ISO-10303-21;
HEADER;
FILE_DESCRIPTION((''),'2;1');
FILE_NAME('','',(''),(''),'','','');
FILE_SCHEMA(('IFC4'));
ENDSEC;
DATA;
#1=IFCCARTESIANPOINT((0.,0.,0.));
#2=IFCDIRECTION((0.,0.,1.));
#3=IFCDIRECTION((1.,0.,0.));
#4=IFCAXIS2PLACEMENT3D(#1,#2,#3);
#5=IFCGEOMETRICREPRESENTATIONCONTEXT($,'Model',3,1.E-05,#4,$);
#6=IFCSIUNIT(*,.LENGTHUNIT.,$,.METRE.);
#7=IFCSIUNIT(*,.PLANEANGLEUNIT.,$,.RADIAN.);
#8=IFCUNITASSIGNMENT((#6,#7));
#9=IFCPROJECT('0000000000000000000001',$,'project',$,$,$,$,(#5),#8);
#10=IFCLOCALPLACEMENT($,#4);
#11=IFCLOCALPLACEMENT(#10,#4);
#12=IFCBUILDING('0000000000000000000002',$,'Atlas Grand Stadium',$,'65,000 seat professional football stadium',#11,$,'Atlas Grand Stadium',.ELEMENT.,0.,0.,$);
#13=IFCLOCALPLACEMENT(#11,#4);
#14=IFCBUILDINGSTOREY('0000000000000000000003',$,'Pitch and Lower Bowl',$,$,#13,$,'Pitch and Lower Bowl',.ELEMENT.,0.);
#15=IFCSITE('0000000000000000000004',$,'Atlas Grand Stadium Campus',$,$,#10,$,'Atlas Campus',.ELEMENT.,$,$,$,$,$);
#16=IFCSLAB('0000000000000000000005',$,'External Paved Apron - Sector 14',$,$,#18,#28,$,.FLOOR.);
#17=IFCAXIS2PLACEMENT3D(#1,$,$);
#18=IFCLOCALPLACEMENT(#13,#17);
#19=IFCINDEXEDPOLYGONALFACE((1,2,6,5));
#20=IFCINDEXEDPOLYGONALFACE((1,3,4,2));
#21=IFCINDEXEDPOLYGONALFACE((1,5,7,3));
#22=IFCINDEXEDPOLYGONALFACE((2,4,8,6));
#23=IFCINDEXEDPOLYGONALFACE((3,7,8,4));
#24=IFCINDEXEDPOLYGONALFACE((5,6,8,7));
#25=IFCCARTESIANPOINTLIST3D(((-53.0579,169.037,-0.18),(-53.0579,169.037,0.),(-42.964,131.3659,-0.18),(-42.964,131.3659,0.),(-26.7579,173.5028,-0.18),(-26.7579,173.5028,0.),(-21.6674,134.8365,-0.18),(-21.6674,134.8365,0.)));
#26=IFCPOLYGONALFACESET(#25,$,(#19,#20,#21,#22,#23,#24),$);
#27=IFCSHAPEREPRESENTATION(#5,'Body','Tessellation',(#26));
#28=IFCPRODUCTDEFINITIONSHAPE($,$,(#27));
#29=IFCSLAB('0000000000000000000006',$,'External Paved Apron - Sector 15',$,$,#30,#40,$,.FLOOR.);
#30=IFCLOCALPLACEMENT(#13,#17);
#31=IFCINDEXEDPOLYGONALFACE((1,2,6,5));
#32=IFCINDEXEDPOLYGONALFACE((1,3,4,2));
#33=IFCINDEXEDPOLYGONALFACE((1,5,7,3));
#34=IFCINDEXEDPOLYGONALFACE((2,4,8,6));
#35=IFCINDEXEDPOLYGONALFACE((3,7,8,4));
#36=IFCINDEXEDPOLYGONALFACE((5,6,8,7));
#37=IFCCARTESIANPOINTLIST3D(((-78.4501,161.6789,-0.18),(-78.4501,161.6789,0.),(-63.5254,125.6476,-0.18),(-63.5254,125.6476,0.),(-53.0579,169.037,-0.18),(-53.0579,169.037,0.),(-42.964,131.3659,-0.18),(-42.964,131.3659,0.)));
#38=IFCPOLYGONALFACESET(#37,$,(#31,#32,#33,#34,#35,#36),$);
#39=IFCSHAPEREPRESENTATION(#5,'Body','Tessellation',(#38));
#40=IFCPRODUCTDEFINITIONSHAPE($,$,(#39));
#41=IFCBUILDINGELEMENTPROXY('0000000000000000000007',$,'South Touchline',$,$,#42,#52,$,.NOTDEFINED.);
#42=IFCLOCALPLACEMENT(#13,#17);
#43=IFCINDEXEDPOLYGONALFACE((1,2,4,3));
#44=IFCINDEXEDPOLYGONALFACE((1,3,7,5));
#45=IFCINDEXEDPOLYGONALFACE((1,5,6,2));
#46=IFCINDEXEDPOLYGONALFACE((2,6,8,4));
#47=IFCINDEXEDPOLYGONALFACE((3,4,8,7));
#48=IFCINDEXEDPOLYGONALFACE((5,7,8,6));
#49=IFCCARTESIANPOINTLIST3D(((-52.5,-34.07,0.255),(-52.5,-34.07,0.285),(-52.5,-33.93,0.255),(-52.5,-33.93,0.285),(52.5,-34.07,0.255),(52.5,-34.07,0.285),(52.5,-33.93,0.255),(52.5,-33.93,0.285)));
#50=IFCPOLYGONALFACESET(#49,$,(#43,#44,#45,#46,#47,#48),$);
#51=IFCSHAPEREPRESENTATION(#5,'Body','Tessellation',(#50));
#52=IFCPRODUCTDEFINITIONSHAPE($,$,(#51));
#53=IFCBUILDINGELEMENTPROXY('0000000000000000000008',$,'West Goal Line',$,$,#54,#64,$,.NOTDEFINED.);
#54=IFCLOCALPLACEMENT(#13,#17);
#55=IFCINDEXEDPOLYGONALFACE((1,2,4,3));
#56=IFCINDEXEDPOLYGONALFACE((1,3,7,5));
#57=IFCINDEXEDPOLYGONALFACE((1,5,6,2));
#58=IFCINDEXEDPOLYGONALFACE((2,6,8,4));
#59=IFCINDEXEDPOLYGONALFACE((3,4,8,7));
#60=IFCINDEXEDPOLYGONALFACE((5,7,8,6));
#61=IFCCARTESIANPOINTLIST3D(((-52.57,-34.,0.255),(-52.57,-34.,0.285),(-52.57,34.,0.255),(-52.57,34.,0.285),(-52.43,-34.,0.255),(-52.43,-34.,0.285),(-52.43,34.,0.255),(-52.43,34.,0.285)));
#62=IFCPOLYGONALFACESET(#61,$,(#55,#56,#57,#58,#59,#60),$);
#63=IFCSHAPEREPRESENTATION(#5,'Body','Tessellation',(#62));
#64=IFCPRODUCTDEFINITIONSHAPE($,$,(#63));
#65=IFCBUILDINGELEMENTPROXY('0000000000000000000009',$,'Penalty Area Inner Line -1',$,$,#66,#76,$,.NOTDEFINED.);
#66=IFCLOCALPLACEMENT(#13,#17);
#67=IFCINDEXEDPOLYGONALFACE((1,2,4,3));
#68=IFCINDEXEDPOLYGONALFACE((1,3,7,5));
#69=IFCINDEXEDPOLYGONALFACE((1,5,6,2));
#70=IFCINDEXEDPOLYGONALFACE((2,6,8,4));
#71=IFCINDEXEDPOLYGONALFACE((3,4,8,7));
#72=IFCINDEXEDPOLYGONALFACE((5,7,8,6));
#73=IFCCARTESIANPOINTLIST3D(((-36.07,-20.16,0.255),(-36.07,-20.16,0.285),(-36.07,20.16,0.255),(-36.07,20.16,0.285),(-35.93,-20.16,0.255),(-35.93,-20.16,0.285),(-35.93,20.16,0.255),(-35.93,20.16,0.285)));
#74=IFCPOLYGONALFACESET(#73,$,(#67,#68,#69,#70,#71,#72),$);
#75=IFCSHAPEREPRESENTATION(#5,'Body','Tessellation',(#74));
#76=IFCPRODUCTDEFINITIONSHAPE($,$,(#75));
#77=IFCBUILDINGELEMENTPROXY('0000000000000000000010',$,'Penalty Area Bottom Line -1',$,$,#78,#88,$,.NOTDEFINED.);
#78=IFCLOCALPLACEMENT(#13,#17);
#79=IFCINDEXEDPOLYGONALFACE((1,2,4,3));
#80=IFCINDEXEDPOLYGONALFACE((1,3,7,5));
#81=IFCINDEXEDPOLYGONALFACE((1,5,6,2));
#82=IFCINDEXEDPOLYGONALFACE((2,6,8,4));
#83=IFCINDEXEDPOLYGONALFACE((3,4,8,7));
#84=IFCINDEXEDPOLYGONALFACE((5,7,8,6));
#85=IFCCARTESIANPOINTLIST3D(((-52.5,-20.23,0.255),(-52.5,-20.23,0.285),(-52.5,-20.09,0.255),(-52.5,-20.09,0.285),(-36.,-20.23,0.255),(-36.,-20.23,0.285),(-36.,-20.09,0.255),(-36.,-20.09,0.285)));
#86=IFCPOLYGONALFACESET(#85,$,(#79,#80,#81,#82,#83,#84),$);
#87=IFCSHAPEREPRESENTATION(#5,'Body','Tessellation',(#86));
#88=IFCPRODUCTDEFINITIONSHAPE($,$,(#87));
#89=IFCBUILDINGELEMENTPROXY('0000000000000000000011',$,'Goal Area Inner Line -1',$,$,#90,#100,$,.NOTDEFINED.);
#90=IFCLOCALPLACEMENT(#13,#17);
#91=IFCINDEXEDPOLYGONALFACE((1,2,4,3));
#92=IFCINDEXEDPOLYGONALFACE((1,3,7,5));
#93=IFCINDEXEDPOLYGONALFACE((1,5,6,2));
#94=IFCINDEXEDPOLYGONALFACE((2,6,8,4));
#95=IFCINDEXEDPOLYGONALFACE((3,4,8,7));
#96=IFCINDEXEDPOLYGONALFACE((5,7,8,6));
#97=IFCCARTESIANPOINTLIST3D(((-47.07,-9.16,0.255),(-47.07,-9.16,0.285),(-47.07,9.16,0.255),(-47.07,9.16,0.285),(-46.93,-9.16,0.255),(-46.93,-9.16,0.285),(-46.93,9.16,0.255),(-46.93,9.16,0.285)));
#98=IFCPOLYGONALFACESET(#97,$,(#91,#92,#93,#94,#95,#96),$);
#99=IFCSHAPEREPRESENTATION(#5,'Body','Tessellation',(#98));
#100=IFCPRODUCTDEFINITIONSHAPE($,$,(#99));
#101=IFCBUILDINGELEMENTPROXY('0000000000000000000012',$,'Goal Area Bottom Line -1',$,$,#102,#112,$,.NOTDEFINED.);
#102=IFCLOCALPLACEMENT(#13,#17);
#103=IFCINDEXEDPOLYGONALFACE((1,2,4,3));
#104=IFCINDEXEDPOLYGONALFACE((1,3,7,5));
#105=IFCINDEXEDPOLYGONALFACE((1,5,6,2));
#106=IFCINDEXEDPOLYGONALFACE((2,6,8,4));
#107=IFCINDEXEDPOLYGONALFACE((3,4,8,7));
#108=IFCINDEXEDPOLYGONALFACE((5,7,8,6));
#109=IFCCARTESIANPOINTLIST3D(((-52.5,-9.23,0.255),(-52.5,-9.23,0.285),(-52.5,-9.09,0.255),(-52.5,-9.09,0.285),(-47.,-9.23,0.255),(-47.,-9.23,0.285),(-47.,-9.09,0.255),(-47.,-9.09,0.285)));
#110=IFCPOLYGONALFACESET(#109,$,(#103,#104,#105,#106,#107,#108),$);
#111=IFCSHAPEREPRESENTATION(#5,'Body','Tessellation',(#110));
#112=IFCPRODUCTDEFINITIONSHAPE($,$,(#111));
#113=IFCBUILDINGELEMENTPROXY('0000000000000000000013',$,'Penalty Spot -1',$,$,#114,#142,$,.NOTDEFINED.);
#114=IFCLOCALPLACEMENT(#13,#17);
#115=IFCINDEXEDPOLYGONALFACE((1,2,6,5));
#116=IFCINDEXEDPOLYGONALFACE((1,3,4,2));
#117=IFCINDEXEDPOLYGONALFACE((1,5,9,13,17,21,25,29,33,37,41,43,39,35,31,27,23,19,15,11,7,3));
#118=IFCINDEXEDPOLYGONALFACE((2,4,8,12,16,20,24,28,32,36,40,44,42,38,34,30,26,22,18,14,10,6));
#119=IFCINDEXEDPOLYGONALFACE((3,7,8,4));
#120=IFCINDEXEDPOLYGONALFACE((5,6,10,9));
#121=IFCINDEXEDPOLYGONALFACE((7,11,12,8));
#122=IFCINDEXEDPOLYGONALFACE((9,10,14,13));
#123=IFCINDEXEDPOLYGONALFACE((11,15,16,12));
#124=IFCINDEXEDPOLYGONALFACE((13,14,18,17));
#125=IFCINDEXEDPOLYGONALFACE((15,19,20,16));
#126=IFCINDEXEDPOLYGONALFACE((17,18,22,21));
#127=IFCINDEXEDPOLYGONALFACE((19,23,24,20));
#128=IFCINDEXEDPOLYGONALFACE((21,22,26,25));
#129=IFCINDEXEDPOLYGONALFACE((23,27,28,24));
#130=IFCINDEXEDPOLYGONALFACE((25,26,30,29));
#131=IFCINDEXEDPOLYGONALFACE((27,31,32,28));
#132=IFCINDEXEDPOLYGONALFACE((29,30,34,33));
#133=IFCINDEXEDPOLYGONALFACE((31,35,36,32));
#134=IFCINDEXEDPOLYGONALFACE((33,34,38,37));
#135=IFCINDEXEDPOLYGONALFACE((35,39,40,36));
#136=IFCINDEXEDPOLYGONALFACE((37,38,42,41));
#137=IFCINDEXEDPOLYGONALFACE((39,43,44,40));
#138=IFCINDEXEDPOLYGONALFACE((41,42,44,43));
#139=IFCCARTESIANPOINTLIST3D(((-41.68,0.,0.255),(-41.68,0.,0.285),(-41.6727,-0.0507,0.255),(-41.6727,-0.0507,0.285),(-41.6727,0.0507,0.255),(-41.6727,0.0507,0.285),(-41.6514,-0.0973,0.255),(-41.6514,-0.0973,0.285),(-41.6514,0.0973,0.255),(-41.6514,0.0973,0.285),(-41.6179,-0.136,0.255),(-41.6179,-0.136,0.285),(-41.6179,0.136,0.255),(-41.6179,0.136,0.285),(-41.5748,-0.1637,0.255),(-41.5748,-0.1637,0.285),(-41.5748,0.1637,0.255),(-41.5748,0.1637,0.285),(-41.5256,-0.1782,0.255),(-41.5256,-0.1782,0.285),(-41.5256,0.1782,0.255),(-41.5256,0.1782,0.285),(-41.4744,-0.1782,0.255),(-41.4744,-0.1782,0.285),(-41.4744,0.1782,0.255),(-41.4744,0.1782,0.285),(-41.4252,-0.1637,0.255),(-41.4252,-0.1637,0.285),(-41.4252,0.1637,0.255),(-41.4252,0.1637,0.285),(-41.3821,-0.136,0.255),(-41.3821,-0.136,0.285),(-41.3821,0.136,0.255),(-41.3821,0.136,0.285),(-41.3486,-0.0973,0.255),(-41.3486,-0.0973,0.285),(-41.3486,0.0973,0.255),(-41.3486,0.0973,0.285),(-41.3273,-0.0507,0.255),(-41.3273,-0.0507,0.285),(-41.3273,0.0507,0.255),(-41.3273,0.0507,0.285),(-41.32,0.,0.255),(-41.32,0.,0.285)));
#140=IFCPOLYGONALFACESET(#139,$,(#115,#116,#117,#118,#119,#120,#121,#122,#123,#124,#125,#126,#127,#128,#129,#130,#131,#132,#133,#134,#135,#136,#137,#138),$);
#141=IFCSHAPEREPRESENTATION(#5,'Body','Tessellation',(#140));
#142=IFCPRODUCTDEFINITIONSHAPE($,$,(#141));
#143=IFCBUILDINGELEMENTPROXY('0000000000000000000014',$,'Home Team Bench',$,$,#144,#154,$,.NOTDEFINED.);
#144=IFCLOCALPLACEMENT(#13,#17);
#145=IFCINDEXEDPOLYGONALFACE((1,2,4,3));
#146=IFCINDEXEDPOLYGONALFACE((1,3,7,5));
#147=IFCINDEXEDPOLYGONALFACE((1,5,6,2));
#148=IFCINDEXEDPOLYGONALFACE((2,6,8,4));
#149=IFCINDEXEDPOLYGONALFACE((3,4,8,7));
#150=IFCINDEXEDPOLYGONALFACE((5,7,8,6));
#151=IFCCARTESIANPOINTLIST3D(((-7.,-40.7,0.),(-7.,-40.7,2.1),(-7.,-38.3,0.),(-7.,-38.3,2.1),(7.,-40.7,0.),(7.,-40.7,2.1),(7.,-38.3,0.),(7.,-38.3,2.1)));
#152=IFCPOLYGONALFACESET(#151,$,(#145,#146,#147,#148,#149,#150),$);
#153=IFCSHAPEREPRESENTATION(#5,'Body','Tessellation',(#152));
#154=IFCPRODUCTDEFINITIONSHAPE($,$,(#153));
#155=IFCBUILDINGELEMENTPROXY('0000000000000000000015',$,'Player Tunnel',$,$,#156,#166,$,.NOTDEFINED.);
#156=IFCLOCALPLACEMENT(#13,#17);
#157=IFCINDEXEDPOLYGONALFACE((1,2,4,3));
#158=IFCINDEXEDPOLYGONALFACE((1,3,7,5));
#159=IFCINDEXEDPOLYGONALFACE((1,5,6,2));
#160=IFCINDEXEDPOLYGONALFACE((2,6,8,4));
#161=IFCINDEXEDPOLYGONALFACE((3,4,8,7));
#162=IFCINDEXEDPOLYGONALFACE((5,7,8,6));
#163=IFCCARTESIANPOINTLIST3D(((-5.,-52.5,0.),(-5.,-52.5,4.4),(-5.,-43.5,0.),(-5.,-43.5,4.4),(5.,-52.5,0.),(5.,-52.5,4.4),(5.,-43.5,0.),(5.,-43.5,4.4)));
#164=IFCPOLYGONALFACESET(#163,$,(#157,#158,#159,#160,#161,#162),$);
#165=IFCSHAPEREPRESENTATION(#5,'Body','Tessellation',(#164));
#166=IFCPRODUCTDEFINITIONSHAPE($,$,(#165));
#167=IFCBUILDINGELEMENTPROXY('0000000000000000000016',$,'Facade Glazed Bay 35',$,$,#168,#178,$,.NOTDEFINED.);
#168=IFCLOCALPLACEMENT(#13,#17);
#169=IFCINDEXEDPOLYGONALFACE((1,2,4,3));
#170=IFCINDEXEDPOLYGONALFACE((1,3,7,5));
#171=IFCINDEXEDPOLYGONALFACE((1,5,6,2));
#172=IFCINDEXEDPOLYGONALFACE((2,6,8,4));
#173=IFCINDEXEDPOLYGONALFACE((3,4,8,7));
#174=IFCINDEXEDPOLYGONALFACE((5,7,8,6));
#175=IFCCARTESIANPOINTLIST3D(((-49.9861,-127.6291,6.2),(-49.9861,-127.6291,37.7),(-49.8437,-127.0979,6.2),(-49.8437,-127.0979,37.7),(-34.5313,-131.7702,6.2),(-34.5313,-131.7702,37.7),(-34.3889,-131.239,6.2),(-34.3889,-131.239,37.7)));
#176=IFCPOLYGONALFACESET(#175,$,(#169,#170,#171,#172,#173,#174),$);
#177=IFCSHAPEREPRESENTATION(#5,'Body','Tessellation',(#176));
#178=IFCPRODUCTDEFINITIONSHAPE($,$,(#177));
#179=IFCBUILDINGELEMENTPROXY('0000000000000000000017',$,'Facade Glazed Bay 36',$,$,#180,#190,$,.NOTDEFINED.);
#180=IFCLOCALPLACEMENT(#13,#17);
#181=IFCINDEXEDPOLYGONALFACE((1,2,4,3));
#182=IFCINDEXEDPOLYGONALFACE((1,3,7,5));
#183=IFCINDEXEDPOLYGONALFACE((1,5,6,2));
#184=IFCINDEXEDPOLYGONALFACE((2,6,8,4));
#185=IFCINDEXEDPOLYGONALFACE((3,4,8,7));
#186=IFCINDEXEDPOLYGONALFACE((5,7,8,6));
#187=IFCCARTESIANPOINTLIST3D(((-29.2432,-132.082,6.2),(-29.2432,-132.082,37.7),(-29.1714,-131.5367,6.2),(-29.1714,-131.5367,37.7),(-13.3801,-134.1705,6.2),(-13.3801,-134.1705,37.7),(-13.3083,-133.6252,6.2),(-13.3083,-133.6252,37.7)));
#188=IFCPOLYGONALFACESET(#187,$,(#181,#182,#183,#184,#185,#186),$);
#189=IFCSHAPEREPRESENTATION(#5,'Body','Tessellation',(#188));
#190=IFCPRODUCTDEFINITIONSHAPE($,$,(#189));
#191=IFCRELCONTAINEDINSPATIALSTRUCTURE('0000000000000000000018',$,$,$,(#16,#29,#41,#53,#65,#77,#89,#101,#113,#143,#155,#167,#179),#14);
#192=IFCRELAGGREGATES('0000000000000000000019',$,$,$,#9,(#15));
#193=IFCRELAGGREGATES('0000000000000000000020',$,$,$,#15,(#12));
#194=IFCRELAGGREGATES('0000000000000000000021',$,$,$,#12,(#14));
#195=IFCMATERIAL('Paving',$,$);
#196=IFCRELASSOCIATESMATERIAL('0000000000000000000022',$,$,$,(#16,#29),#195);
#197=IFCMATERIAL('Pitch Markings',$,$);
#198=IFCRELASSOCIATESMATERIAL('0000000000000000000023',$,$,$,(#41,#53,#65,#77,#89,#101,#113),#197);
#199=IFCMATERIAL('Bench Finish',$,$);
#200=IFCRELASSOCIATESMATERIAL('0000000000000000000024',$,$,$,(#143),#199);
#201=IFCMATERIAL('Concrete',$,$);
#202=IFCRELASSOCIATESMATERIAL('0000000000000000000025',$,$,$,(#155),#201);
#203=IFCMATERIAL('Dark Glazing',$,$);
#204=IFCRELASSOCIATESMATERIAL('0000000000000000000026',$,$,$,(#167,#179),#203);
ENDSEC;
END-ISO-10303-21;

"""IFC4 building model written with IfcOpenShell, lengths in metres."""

from ifc_helpers import new_model, si_unit, frame, origin_with_axes, origin_2d_with_axis, place, context, project, spatial, polyline, rectangle, circle, outline, extrude, material, element, save


model = new_model("IFC4")

# Units and contexts
model_context = context("Model", 3, precision=1e-05, world=origin_with_axes())
ifc_project = project(units=[si_unit("LENGTHUNIT", "METRE"), si_unit("PLANEANGLEUNIT", "RADIAN")], contexts=[model_context])

# Site, building, storey
site_placement = place(None, origin_with_axes())
site = spatial("IfcSite", under=ifc_project, at=site_placement, Name="Atlas Grand Stadium Campus", LongName="Atlas Campus", CompositionType="ELEMENT")
building_placement = place(site_placement, origin_with_axes())
building = spatial("IfcBuilding", under=site, at=building_placement, Name="Atlas Grand Stadium", ObjectType="65,000 seat professional football stadium", LongName="Atlas Grand Stadium", CompositionType="ELEMENT", ElevationOfRefHeight=0.0, ElevationOfTerrain=0.0)
storey_placement = place(building_placement, origin_with_axes())
storey = spatial("IfcBuildingStorey", under=building, at=storey_placement, Name="Pitch and Lower Bowl", LongName="Pitch and Lower Bowl", CompositionType="ELEMENT", Elevation=0.0)

# Slabs
ifc_material_1 = material(Name="Paving")
slab_1_placement = place(storey_placement, frame((0.0, 0.0, -0.18), z_axis=(0.0, 0.0, 1.0), x_axis=(1.0, 0.0, 0.0)))
element("IfcSlab", 1, at=slab_1_placement, inside=storey, material=ifc_material_1, Name="External Paved Apron - Sector 14", PredefinedType="FLOOR", context=model_context, shape_type="SweptSolid", body=[
    extrude(outline(polyline([(-26.7579, 173.5028), (-53.0579, 169.037), (-42.964, 131.3659), (-21.6673, 134.8365), (-26.7579, 173.5028)])), origin_with_axes(), (0.0, 0.0, 1.0), 0.18),
])
slab_2_placement = place(storey_placement, frame((0.0, 0.0, -0.18), z_axis=(0.0, 0.0, 1.0), x_axis=(1.0, 0.0, 0.0)))
element("IfcSlab", 2, at=slab_2_placement, inside=storey, material=ifc_material_1, Name="External Paved Apron - Sector 15", PredefinedType="FLOOR", context=model_context, shape_type="SweptSolid", body=[
    extrude(outline(polyline([(-53.0579, 169.037), (-78.4501, 161.6789), (-63.5254, 125.6476), (-42.964, 131.3659), (-53.0579, 169.037)])), origin_with_axes(), (0.0, 0.0, 1.0), 0.18),
])

# Building element proxies
ifc_material_2 = material(Name="Pitch Markings")
proxy_1_placement = place(storey_placement, frame((0.0, -34.0, 0.255), z_axis=(0.0, 0.0, 1.0), x_axis=(1.0, 0.0, 0.0)))
element("IfcBuildingElementProxy", 3, at=proxy_1_placement, inside=storey, material=ifc_material_2, Name="South Touchline", PredefinedType="NOTDEFINED", context=model_context, shape_type="SweptSolid", body=[
    extrude(rectangle(XDim=105.0, YDim=0.14, at=origin_2d_with_axis()), origin_with_axes(), (0.0, 0.0, 1.0), 0.03),
])
proxy_2_placement = place(storey_placement, frame((-52.5, 0.0, 0.255), z_axis=(0.0, 0.0, 1.0), x_axis=(1.0, 0.0, 0.0)))
element("IfcBuildingElementProxy", 4, at=proxy_2_placement, inside=storey, material=ifc_material_2, Name="West Goal Line", PredefinedType="NOTDEFINED", context=model_context, shape_type="SweptSolid", body=[
    extrude(rectangle(XDim=0.14, YDim=68.0, at=origin_2d_with_axis()), origin_with_axes(), (0.0, 0.0, 1.0), 0.03),
])
proxy_3_placement = place(storey_placement, frame((-36.0, 0.0, 0.255), z_axis=(0.0, 0.0, 1.0), x_axis=(1.0, 0.0, 0.0)))
element("IfcBuildingElementProxy", 5, at=proxy_3_placement, inside=storey, material=ifc_material_2, Name="Penalty Area Inner Line -1", PredefinedType="NOTDEFINED", context=model_context, shape_type="SweptSolid", body=[
    extrude(rectangle(XDim=0.14, YDim=40.32, at=origin_2d_with_axis()), origin_with_axes(), (0.0, 0.0, 1.0), 0.03),
])
proxy_4_placement = place(storey_placement, frame((-44.25, -20.16, 0.255), z_axis=(0.0, 0.0, 1.0), x_axis=(1.0, 0.0, 0.0)))
element("IfcBuildingElementProxy", 6, at=proxy_4_placement, inside=storey, material=ifc_material_2, Name="Penalty Area Bottom Line -1", PredefinedType="NOTDEFINED", context=model_context, shape_type="SweptSolid", body=[
    extrude(rectangle(XDim=16.5, YDim=0.14, at=origin_2d_with_axis()), origin_with_axes(), (0.0, 0.0, 1.0), 0.03),
])
proxy_5_placement = place(storey_placement, frame((-47.0, 0.0, 0.255), z_axis=(0.0, 0.0, 1.0), x_axis=(1.0, 0.0, 0.0)))
element("IfcBuildingElementProxy", 7, at=proxy_5_placement, inside=storey, material=ifc_material_2, Name="Goal Area Inner Line -1", PredefinedType="NOTDEFINED", context=model_context, shape_type="SweptSolid", body=[
    extrude(rectangle(XDim=0.14, YDim=18.32, at=origin_2d_with_axis()), origin_with_axes(), (0.0, 0.0, 1.0), 0.03),
])
proxy_6_placement = place(storey_placement, frame((-49.75, -9.16, 0.255), z_axis=(0.0, 0.0, 1.0), x_axis=(1.0, 0.0, 0.0)))
element("IfcBuildingElementProxy", 8, at=proxy_6_placement, inside=storey, material=ifc_material_2, Name="Goal Area Bottom Line -1", PredefinedType="NOTDEFINED", context=model_context, shape_type="SweptSolid", body=[
    extrude(rectangle(XDim=5.5, YDim=0.14, at=origin_2d_with_axis()), origin_with_axes(), (0.0, 0.0, 1.0), 0.03),
])
proxy_7_placement = place(storey_placement, frame((-41.5, 0.0, 0.255), z_axis=(0.0, 0.0, 1.0), x_axis=(1.0, 0.0, 0.0)))
element("IfcBuildingElementProxy", 9, at=proxy_7_placement, inside=storey, material=ifc_material_2, Name="Penalty Spot -1", PredefinedType="NOTDEFINED", context=model_context, shape_type="SweptSolid", body=[
    extrude(circle(Radius=0.18, at=origin_2d_with_axis()), origin_with_axes(), (0.0, 0.0, 1.0), 0.03),
])
ifc_material_3 = material(Name="Bench Finish")
proxy_8_placement = place(storey_placement, frame((0.0, -39.5, 0.0), z_axis=(0.0, 0.0, 1.0), x_axis=(1.0, 0.0, 0.0)))
element("IfcBuildingElementProxy", 10, at=proxy_8_placement, inside=storey, material=ifc_material_3, Name="Home Team Bench", PredefinedType="NOTDEFINED", context=model_context, shape_type="SweptSolid", body=[
    extrude(rectangle(XDim=14.0, YDim=2.4, at=origin_2d_with_axis()), origin_with_axes(), (0.0, 0.0, 1.0), 2.1),
])
ifc_material_4 = material(Name="Concrete")
proxy_9_placement = place(storey_placement, frame((0.0, -48.0, 0.0), z_axis=(0.0, 0.0, 1.0), x_axis=(1.0, 0.0, 0.0)))
element("IfcBuildingElementProxy", 11, at=proxy_9_placement, inside=storey, material=ifc_material_4, Name="Player Tunnel", PredefinedType="NOTDEFINED", context=model_context, shape_type="SweptSolid", body=[
    extrude(rectangle(XDim=10.0, YDim=9.0, at=origin_2d_with_axis()), origin_with_axes(), (0.0, 0.0, 1.0), 4.4),
])
ifc_material_5 = material(Name="Dark Glazing")
for number, where, z_axis, x_axis, name in (
    (12, (-42.1875, -129.4341, 6.2), (0.0, 0.0, 1.0), (0.96593, -0.25882, 0.0), "Facade Glazed Bay 35"),
    (13, (-21.2758, -132.8536, 6.2), (0.0, 0.0, 1.0), (0.99144, -0.13053, 0.0), "Facade Glazed Bay 36"),
):
    element("IfcBuildingElementProxy", number, at=place(storey_placement, frame(where, z_axis=z_axis, x_axis=x_axis)), inside=storey, material=ifc_material_5, Name=name, PredefinedType="NOTDEFINED", context=model_context, shape_type="SweptSolid", body=[
        extrude(rectangle(XDim=16.0, YDim=0.55, at=origin_2d_with_axis()), origin_with_axes(), (0.0, 0.0, 1.0), 31.5),
    ])

save(model, "model.ifc")
